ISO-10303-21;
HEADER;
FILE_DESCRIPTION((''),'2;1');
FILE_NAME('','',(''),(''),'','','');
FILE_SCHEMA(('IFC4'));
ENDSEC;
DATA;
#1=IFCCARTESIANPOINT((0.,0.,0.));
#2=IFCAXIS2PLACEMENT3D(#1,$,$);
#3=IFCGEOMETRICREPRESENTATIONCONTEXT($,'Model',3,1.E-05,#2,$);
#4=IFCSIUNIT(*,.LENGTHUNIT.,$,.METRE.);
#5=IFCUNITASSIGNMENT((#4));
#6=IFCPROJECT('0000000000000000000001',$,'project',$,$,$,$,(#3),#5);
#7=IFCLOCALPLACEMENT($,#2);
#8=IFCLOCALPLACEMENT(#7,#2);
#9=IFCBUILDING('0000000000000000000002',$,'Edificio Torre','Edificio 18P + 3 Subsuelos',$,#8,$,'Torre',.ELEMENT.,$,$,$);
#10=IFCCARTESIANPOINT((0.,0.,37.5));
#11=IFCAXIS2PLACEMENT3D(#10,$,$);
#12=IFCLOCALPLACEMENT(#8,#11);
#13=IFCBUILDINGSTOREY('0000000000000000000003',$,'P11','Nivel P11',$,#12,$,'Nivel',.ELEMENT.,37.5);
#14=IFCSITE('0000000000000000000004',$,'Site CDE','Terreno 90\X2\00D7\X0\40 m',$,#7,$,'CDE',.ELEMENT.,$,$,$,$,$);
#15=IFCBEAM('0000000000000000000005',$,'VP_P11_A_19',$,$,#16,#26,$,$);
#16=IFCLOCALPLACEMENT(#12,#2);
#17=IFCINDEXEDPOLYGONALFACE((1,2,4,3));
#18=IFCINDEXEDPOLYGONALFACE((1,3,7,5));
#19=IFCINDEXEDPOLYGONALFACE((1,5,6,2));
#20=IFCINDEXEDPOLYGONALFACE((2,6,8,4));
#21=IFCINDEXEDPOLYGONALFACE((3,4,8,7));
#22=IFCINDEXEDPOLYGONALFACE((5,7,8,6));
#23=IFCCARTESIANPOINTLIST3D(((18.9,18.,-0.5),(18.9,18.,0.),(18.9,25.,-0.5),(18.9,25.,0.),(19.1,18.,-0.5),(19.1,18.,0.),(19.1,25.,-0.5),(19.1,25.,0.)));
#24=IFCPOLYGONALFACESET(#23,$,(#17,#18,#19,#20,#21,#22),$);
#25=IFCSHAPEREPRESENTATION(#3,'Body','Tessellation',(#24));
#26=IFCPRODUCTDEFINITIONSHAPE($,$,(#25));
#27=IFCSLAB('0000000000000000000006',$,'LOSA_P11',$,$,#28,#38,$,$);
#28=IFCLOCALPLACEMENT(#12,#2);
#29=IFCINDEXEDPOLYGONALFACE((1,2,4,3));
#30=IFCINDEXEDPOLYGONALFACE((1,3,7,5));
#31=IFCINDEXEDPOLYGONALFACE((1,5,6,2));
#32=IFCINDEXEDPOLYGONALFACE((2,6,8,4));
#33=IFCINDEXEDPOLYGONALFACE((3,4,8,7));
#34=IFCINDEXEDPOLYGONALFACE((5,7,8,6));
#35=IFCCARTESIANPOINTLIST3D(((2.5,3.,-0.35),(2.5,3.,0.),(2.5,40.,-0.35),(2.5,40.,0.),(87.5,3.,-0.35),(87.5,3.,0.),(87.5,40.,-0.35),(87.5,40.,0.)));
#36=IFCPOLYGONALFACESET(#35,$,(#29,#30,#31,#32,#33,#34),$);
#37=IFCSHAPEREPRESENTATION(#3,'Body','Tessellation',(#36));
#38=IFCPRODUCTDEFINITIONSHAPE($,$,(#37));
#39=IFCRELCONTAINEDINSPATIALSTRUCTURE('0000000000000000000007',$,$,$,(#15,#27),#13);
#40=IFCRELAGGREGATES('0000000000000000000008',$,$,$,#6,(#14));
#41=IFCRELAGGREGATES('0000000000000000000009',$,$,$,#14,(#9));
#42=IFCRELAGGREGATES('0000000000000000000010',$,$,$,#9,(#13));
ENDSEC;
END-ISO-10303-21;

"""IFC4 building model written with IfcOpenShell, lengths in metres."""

from ifc_helpers import new_model, si_unit, frame, origin, origin_2d, place, context, project, spatial, rectangle, extrude, element, save


model = new_model("IFC4")

# Units and contexts
model_context = context("Model", 3, precision=1e-05, world=origin())
ifc_project = project(units=[si_unit("LENGTHUNIT", "METRE")], contexts=[model_context])

# Site, building, storey
site_placement = place(None, origin())
site = spatial("IfcSite", under=ifc_project, at=site_placement, Name="Site CDE", Description="Terreno 90×40 m", LongName="CDE", CompositionType="ELEMENT")
building_placement = place(site_placement, origin())
building = spatial("IfcBuilding", under=site, at=building_placement, Name="Edificio Torre", Description="Edificio 18P + 3 Subsuelos", LongName="Torre", CompositionType="ELEMENT")
storey_placement = place(building_placement, frame((0.0, 0.0, 37.5)))
storey = spatial("IfcBuildingStorey", under=building, at=storey_placement, Name="P11", Description="Nivel P11", LongName="Nivel", CompositionType="ELEMENT", Elevation=37.5)

# Beam
beam_1_placement = place(storey_placement, frame((19.0, 21.5, -0.5)))
element("IfcBeam", 1, at=beam_1_placement, inside=storey, Name="VP_P11_A_19", context=model_context, shape_type="SweptSolid", body=[
    extrude(rectangle(XDim=0.2, YDim=7.0, at=origin_2d()), origin(), (0.0, 0.0, 1.0), 0.5),
])

# Slab
slab_placement = place(storey_placement, frame((45.0, 21.5, -0.35)))
element("IfcSlab", 2, at=slab_placement, inside=storey, Name="LOSA_P11", context=model_context, shape_type="SweptSolid", body=[
    extrude(rectangle(XDim=85.0, YDim=37.0, at=origin_2d()), origin(), (0.0, 0.0, 1.0), 0.35),
])

save(model, "model.ifc")
